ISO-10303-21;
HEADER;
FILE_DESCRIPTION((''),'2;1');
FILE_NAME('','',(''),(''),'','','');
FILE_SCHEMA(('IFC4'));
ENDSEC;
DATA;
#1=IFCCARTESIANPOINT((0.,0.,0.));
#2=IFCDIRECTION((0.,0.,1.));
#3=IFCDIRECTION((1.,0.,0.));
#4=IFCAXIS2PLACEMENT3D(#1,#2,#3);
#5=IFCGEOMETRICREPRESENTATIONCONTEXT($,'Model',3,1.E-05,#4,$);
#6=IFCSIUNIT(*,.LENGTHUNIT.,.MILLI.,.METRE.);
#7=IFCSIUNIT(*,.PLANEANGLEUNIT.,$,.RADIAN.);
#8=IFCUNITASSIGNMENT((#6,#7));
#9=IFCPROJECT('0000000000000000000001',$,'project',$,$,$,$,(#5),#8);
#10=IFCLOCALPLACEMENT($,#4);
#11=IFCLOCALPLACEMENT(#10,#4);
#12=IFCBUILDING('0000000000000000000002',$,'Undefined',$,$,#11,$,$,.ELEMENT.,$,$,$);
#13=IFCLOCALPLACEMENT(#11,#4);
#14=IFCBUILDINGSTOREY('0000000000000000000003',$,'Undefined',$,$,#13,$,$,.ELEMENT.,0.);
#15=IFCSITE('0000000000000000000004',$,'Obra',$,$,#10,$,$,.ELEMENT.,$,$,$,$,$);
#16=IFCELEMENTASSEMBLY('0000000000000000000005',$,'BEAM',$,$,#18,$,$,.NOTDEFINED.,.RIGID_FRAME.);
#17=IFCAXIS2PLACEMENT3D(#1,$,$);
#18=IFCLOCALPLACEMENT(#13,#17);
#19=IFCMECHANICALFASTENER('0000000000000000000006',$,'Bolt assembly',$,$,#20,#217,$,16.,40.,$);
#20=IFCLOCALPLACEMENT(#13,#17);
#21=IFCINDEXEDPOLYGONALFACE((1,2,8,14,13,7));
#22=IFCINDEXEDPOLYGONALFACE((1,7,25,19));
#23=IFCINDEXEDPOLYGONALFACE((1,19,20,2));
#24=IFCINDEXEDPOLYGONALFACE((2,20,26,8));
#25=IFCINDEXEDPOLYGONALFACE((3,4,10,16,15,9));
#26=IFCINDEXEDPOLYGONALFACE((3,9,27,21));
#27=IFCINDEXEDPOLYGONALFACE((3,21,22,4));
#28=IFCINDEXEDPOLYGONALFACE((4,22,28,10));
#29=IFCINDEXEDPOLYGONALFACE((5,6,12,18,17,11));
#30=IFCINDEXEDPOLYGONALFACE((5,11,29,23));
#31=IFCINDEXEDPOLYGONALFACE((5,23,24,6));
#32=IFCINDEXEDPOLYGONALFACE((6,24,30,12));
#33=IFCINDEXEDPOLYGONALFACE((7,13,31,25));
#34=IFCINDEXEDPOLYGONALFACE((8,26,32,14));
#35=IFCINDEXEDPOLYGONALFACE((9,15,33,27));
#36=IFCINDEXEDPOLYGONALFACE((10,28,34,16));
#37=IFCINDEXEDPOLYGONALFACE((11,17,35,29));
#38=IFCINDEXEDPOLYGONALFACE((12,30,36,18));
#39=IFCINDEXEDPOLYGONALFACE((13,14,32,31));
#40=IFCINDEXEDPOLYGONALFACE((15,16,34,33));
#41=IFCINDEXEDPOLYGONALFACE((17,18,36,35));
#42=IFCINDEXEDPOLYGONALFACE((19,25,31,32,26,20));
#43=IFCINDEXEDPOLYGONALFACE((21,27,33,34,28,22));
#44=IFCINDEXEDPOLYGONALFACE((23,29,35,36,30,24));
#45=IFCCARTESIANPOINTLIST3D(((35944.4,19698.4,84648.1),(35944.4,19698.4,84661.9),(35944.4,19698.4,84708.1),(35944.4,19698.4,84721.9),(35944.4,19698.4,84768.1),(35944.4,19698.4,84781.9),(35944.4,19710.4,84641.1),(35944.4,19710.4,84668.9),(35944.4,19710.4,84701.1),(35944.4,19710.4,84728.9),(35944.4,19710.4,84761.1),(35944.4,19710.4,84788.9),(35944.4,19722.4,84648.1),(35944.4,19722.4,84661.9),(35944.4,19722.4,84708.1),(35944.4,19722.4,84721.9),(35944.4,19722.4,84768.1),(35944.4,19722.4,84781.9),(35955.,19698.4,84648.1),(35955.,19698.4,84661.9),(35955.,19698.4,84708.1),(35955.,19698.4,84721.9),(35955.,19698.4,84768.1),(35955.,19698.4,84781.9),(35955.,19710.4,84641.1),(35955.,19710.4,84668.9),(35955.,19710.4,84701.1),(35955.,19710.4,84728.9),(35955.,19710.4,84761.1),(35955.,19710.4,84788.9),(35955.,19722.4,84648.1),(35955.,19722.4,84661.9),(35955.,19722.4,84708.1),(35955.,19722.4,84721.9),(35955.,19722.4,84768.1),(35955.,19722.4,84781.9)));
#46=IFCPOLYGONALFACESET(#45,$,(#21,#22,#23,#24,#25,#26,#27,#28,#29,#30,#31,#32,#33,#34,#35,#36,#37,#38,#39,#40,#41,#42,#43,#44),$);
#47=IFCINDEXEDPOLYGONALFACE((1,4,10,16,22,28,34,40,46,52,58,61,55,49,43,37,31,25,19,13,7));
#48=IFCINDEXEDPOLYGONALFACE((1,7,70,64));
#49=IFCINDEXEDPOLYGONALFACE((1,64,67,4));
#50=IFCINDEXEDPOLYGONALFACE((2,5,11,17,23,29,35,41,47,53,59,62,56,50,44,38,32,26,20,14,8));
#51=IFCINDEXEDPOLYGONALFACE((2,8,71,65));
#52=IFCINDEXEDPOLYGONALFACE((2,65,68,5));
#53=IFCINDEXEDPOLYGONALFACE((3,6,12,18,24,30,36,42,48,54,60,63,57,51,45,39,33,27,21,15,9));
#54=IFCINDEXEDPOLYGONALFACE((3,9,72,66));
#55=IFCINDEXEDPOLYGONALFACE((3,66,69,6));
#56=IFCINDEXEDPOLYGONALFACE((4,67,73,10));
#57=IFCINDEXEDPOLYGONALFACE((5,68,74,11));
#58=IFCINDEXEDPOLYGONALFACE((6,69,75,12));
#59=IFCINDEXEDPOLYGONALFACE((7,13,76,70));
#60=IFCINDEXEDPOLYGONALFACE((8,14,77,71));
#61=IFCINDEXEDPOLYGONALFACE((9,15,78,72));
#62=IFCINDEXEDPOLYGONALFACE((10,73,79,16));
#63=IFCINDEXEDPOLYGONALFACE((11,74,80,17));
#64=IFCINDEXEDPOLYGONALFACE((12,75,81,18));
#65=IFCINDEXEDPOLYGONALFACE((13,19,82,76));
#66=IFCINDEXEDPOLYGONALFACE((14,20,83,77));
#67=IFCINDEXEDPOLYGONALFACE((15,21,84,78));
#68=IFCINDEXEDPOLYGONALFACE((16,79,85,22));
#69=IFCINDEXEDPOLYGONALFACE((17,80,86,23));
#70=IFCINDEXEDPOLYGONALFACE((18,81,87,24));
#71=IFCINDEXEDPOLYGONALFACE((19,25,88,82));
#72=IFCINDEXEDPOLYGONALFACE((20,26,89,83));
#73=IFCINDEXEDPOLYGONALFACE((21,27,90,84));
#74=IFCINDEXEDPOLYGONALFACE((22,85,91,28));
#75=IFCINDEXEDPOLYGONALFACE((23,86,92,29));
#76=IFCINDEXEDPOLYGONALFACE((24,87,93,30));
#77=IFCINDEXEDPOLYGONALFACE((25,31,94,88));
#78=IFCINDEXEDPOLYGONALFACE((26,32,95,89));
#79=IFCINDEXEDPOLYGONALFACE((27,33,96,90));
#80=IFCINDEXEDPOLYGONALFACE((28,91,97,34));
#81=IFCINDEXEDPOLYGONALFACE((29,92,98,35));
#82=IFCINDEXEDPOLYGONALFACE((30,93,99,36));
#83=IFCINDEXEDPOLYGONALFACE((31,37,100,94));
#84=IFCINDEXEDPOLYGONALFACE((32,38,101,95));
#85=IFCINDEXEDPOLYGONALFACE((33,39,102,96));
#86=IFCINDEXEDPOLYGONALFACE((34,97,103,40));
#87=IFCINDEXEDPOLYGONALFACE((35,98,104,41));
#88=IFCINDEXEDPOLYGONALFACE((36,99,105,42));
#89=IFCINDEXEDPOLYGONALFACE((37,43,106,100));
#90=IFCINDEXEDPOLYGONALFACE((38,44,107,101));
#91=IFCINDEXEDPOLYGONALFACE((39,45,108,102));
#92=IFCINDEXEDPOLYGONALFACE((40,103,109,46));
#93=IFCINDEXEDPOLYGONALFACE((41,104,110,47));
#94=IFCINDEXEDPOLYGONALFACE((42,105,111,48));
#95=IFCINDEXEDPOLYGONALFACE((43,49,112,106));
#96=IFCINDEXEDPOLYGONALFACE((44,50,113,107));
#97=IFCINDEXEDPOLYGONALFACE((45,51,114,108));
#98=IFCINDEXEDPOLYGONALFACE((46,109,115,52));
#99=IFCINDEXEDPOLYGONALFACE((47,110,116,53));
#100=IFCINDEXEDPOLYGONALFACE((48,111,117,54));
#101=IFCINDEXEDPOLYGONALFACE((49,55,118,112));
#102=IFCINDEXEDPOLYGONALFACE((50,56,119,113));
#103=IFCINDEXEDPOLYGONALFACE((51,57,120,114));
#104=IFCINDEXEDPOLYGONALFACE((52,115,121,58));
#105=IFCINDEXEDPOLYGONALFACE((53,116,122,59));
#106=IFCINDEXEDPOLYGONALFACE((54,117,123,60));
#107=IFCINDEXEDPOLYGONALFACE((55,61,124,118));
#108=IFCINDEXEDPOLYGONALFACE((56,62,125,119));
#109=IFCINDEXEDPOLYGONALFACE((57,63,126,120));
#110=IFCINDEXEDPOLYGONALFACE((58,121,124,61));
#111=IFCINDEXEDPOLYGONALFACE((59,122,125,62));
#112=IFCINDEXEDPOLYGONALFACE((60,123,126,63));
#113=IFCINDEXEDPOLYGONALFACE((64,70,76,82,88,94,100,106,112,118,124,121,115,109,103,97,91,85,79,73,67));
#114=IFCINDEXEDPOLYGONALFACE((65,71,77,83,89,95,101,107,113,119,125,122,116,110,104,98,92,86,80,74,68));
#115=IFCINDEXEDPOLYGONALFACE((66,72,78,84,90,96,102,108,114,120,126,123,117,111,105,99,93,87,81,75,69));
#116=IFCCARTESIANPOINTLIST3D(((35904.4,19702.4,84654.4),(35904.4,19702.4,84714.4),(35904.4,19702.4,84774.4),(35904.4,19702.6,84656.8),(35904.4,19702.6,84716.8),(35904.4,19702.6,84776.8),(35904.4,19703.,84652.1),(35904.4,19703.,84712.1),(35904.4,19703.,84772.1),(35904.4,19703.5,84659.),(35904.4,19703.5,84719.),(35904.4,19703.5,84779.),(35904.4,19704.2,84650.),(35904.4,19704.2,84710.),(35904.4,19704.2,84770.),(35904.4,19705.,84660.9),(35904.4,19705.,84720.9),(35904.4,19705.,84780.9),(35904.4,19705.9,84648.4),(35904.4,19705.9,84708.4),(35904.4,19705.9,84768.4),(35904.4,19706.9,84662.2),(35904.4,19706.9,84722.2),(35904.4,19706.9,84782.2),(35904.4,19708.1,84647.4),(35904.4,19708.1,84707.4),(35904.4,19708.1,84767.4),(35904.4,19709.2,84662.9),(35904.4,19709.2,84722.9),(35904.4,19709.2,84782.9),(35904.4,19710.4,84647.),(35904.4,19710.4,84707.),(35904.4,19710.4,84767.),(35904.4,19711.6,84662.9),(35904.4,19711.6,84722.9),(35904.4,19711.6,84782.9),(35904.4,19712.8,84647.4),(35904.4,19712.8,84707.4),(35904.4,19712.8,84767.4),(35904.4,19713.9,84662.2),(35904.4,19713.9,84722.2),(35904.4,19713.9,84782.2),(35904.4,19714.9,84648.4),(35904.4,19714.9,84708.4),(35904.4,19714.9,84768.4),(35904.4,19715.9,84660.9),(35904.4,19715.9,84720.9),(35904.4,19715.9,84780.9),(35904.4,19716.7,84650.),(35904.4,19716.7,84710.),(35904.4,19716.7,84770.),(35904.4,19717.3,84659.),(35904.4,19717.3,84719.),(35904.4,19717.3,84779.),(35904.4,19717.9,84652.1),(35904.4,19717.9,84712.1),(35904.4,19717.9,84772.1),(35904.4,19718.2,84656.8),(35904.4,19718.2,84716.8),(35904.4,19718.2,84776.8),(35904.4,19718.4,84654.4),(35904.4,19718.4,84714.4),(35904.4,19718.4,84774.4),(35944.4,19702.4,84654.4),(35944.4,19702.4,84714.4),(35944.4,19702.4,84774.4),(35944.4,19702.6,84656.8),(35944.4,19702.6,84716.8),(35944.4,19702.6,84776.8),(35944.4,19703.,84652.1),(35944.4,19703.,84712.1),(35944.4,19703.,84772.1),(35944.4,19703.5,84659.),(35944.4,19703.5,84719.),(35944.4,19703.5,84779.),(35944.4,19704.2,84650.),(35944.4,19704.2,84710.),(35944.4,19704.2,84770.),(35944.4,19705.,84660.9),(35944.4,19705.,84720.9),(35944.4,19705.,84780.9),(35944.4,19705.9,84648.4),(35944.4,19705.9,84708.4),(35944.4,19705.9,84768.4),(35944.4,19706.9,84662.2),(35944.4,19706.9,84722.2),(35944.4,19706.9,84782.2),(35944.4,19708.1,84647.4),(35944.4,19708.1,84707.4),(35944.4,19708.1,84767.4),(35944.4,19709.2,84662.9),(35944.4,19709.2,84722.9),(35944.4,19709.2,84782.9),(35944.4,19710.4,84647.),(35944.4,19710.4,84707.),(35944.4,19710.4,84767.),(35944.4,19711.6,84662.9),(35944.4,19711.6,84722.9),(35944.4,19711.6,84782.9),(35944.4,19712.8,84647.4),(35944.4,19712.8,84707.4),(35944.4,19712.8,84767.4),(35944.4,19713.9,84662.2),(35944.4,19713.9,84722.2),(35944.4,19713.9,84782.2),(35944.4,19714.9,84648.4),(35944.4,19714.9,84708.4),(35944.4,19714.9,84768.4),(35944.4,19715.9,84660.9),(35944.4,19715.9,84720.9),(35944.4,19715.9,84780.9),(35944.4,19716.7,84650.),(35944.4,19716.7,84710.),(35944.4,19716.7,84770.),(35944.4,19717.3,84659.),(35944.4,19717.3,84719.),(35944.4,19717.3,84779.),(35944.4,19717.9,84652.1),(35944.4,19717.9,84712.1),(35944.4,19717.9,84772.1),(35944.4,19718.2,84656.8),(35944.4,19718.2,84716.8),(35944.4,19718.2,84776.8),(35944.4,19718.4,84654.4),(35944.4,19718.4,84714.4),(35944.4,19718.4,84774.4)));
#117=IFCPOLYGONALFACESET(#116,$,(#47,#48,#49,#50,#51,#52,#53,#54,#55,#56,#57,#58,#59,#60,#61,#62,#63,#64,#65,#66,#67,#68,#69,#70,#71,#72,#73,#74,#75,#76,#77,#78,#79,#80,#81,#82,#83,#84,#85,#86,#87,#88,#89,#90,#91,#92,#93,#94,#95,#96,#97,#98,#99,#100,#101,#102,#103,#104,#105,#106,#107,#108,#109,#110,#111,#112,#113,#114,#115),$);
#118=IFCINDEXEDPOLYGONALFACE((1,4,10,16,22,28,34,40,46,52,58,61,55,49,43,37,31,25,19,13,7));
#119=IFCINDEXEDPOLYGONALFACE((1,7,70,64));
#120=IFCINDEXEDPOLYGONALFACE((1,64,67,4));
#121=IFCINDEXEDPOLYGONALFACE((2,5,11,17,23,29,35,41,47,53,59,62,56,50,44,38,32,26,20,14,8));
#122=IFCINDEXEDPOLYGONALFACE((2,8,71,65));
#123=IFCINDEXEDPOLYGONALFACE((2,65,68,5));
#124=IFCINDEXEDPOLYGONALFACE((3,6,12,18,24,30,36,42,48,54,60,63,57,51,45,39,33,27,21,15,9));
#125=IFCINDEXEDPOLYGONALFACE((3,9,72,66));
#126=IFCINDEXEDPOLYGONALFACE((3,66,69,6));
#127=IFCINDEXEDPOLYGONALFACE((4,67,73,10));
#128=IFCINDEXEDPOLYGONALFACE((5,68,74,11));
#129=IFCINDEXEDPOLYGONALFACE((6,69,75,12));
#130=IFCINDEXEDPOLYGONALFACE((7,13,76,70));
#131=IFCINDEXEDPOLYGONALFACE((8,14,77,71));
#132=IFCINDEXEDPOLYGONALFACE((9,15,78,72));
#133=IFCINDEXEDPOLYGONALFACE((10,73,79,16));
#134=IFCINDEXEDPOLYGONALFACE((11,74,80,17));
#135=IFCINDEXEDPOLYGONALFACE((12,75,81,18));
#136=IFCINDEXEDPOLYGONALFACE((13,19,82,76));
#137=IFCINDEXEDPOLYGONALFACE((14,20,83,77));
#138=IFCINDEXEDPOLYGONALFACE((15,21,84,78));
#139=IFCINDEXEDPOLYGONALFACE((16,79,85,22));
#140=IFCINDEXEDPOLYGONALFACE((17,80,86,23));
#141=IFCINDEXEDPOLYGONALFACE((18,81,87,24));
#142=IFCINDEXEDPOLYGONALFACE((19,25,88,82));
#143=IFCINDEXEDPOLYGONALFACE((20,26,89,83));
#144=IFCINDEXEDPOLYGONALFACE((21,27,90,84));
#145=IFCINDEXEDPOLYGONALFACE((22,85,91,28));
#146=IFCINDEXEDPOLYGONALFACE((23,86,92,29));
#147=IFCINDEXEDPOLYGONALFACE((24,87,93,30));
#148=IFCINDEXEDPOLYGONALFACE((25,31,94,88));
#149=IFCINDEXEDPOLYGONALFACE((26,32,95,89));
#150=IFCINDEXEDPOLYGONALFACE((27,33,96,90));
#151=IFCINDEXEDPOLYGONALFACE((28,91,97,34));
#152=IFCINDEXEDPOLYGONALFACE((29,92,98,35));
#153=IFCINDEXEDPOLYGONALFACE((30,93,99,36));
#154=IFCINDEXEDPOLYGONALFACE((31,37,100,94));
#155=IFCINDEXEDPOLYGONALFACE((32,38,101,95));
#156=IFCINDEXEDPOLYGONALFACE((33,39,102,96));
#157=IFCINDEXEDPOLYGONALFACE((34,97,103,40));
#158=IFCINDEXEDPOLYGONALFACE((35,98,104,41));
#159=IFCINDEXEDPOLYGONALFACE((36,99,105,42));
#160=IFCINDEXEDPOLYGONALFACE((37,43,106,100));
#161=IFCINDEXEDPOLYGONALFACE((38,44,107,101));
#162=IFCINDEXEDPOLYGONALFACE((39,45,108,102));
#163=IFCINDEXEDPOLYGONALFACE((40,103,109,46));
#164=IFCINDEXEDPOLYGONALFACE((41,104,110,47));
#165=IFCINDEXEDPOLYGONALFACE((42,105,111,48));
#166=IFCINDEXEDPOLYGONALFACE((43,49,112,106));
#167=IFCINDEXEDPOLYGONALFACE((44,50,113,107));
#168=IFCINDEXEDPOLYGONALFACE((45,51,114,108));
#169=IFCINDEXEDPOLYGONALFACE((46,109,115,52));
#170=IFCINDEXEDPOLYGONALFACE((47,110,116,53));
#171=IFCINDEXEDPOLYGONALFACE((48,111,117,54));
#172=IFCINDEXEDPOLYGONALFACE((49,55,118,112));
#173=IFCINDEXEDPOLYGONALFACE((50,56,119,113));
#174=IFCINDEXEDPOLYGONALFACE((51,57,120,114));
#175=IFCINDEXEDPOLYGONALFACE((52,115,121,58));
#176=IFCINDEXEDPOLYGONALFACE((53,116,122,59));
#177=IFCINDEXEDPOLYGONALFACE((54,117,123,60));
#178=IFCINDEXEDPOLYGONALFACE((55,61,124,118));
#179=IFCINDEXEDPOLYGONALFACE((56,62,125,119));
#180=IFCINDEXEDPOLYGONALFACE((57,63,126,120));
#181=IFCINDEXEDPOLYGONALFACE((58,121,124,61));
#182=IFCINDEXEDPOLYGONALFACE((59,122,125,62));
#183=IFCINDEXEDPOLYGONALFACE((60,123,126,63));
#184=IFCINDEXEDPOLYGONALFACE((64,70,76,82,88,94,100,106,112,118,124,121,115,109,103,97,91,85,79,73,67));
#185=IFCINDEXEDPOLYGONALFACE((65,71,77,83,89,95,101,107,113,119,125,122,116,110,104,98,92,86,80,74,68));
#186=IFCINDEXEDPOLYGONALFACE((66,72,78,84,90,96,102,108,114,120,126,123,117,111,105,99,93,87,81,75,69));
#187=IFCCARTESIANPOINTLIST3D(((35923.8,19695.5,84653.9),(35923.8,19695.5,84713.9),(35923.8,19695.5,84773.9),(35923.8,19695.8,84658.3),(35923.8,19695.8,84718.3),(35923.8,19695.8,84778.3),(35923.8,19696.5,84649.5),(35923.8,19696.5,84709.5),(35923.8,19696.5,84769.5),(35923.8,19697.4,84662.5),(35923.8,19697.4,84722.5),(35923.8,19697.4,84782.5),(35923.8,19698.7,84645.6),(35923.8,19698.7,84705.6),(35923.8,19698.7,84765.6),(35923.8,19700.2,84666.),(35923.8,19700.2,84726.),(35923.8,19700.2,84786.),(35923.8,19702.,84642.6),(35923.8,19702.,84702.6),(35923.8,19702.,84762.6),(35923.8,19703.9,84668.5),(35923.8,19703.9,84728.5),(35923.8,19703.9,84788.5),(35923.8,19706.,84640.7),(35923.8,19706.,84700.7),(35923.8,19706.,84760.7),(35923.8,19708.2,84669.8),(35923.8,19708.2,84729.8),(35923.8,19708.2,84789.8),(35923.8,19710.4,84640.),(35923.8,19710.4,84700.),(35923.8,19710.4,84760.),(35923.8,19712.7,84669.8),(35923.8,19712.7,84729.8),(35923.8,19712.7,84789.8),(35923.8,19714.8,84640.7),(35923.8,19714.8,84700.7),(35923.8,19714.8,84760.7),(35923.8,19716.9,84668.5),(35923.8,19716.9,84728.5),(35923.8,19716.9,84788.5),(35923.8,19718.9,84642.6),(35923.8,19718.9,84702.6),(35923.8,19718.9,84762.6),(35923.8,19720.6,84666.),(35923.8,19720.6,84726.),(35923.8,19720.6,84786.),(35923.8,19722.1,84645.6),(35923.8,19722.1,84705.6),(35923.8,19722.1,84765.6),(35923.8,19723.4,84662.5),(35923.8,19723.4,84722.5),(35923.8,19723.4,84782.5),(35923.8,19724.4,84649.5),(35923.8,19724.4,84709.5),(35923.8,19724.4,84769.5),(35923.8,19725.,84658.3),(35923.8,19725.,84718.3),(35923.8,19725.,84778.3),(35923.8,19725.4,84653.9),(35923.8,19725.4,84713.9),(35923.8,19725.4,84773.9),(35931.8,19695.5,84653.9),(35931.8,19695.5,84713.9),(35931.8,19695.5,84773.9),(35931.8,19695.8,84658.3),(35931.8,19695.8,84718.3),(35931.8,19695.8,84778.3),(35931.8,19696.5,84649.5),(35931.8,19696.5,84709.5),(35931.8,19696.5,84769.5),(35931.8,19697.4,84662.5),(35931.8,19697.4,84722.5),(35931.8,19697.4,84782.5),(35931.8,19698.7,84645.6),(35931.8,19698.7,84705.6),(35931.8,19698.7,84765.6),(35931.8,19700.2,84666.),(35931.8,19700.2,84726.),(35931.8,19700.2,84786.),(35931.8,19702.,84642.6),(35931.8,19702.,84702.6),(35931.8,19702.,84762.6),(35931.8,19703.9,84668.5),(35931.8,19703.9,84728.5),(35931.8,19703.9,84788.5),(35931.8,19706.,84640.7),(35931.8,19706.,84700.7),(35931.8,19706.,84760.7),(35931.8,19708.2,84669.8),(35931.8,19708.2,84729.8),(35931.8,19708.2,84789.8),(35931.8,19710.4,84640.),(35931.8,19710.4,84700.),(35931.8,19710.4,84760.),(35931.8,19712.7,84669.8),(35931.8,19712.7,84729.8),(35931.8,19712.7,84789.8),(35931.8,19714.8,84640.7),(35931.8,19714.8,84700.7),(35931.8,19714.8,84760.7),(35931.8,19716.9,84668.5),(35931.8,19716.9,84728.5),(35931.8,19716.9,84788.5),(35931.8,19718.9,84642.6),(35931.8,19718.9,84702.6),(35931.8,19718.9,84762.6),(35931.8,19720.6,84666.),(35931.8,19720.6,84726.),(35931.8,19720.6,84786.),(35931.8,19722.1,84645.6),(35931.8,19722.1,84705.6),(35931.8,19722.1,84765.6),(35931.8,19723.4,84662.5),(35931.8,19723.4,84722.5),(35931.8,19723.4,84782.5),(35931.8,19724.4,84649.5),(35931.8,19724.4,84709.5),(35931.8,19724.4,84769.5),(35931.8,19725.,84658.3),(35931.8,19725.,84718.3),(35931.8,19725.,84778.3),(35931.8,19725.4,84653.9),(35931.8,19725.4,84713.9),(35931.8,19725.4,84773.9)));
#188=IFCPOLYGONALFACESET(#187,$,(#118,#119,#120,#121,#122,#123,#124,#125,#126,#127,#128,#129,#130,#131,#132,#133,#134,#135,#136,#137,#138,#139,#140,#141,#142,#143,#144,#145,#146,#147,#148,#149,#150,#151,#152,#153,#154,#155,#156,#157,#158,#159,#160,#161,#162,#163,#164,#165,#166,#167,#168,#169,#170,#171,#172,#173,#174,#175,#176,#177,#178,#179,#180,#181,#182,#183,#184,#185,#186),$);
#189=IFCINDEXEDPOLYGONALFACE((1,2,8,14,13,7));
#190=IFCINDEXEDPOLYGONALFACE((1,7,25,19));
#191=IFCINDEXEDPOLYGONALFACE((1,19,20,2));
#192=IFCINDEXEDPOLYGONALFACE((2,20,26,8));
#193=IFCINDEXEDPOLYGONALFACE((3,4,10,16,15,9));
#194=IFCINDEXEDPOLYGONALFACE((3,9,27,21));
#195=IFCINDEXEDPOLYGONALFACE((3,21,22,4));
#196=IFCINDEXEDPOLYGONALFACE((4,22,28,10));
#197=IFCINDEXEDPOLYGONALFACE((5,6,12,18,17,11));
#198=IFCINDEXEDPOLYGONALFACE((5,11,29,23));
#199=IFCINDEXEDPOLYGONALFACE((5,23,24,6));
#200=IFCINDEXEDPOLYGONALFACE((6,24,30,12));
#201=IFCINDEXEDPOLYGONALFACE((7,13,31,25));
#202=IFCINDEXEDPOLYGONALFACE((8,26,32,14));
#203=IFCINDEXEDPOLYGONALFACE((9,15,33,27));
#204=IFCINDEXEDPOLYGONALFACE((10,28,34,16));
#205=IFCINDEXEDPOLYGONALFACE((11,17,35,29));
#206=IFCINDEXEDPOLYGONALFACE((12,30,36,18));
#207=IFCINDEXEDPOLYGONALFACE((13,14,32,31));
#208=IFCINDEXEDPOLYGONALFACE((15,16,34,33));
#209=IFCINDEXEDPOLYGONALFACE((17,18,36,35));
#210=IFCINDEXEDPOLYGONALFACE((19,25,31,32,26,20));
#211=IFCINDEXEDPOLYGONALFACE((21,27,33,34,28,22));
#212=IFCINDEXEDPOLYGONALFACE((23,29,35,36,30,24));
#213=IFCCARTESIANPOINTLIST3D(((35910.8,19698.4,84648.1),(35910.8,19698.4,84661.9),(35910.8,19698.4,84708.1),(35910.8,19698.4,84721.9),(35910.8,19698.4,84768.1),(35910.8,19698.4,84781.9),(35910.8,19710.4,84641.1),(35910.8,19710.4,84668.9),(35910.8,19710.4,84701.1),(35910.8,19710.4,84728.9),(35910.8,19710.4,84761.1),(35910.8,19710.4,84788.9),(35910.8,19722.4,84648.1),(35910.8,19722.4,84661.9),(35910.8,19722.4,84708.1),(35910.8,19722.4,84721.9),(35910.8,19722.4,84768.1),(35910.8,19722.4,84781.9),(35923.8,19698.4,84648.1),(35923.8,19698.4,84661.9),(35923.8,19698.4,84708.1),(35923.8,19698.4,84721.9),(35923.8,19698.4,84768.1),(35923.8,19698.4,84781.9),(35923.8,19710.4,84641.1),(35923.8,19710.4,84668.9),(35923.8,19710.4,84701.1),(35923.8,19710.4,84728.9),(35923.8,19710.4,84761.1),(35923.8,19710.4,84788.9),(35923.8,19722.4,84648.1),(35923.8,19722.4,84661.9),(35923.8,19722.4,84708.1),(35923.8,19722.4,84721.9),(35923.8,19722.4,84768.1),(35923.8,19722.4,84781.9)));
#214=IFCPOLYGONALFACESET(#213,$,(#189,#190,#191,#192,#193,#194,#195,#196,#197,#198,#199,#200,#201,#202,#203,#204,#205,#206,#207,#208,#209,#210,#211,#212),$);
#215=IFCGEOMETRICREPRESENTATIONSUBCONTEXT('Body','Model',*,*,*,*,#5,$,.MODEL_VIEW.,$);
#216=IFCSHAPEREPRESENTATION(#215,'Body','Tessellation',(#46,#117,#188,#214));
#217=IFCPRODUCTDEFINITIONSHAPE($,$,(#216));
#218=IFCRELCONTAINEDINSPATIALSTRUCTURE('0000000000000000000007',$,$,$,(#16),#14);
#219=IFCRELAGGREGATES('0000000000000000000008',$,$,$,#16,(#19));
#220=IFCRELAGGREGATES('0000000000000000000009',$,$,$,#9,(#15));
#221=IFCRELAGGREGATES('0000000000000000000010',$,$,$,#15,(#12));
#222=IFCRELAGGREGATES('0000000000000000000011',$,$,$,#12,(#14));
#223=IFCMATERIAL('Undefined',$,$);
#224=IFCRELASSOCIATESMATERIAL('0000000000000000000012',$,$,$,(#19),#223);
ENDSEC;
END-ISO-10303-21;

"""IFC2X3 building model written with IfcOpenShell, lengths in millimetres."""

from ifc_helpers import new_model, si_unit, frame, origin_with_axes, origin_2d_with_axis, place, context, subcontext, project, spatial, polyline, circle, outline, extrude, source, transform, mapped, material, element, aggregate, save


model = new_model("IFC2X3")

# Units and contexts
model_context = context("Model", 3, precision=1e-05, world=origin_with_axes())
body_context = subcontext(model_context, "Body", "Model", "MODEL_VIEW")
ifc_project = project(units=[si_unit("LENGTHUNIT", "METRE", prefix="MILLI"), si_unit("PLANEANGLEUNIT", "RADIAN")], contexts=[model_context])

# Site, building, storey
site_placement = place(None, origin_with_axes())
site = spatial("IfcSite", under=ifc_project, at=site_placement, Name="Obra", CompositionType="ELEMENT")
building_placement = place(site_placement, origin_with_axes())
building = spatial("IfcBuilding", under=site, at=building_placement, Name="Undefined", CompositionType="ELEMENT")
storey_placement = place(building_placement, origin_with_axes())
storey = spatial("IfcBuildingStorey", under=building, at=storey_placement, Name="Undefined", CompositionType="ELEMENT", Elevation=0.0)

# Element assembly, mechanical fastener
ifc_material_1 = material(Name="Undefined")
assembly_1_placement = place(storey_placement, origin_with_axes())
assembly_1 = element("IfcElementAssembly", 1, at=assembly_1_placement, inside=storey, Name="BEAM", AssemblyPlace="NOTDEFINED", PredefinedType="RIGID_FRAME")
shared_shape_1 = source(origin_with_axes(), body_context, "Body", "SweptSolid", [
    extrude(outline(polyline([(13.9, 0.0), (6.9, 12.0), (-6.9, 12.0), (-13.9, 0.0), (-6.9, -12.0), (6.9, -12.0), (13.9, 0.0)])), frame((0.0, -19.9, 0.0), z_axis=(0.0, 1.0, 0.0), x_axis=(1.0, 0.0, 0.0)), (0.0, 0.0, 1.0), 10.6),
    extrude(circle(Radius=8.0, at=origin_2d_with_axis()), frame((0.0, -9.3, 0.0), z_axis=(0.0, 1.0, 0.0), x_axis=(1.0, 0.0, 0.0)), (0.0, 0.0, 1.0), 40.0),
    extrude(circle(Radius=15.0, at=origin_2d_with_axis()), frame((0.0, 3.3, 0.0), z_axis=(0.0, 1.0, 0.0), x_axis=(1.0, 0.0, 0.0)), (0.0, 0.0, 1.0), 8.0),
    extrude(outline(polyline([(13.9, 0.0), (6.9, 12.0), (-6.9, 12.0), (-13.9, 0.0), (-6.9, -12.0), (6.9, -12.0), (13.9, 0.0)])), frame((0.0, 11.3, 0.0), z_axis=(0.0, 1.0, 0.0), x_axis=(1.0, 0.0, 0.0)), (0.0, 0.0, 1.0), 13.0),
])
mechanical_fastener_1_placement = place(assembly_1_placement, frame((35935.1, 19660.4, 84850.0), z_axis=(0.0, 1.0, 0.0), x_axis=(0.0, 0.0, -1.0)))
mechanical_fastener_1 = element("IfcMechanicalFastener", 2, at=mechanical_fastener_1_placement, material=ifc_material_1, Name="Bolt assembly", NominalDiameter=16.0, NominalLength=40.0, context=body_context, shape_type="MappedRepresentation", body=[
    mapped(shared_shape_1, transform((75.0, 0.0, 50.0))),
    mapped(shared_shape_1, transform((135.0, 0.0, 50.0))),
    mapped(shared_shape_1, transform((195.0, 0.0, 50.0))),
])

aggregate(assembly_1, [mechanical_fastener_1])

save(model, "model.ifc")
